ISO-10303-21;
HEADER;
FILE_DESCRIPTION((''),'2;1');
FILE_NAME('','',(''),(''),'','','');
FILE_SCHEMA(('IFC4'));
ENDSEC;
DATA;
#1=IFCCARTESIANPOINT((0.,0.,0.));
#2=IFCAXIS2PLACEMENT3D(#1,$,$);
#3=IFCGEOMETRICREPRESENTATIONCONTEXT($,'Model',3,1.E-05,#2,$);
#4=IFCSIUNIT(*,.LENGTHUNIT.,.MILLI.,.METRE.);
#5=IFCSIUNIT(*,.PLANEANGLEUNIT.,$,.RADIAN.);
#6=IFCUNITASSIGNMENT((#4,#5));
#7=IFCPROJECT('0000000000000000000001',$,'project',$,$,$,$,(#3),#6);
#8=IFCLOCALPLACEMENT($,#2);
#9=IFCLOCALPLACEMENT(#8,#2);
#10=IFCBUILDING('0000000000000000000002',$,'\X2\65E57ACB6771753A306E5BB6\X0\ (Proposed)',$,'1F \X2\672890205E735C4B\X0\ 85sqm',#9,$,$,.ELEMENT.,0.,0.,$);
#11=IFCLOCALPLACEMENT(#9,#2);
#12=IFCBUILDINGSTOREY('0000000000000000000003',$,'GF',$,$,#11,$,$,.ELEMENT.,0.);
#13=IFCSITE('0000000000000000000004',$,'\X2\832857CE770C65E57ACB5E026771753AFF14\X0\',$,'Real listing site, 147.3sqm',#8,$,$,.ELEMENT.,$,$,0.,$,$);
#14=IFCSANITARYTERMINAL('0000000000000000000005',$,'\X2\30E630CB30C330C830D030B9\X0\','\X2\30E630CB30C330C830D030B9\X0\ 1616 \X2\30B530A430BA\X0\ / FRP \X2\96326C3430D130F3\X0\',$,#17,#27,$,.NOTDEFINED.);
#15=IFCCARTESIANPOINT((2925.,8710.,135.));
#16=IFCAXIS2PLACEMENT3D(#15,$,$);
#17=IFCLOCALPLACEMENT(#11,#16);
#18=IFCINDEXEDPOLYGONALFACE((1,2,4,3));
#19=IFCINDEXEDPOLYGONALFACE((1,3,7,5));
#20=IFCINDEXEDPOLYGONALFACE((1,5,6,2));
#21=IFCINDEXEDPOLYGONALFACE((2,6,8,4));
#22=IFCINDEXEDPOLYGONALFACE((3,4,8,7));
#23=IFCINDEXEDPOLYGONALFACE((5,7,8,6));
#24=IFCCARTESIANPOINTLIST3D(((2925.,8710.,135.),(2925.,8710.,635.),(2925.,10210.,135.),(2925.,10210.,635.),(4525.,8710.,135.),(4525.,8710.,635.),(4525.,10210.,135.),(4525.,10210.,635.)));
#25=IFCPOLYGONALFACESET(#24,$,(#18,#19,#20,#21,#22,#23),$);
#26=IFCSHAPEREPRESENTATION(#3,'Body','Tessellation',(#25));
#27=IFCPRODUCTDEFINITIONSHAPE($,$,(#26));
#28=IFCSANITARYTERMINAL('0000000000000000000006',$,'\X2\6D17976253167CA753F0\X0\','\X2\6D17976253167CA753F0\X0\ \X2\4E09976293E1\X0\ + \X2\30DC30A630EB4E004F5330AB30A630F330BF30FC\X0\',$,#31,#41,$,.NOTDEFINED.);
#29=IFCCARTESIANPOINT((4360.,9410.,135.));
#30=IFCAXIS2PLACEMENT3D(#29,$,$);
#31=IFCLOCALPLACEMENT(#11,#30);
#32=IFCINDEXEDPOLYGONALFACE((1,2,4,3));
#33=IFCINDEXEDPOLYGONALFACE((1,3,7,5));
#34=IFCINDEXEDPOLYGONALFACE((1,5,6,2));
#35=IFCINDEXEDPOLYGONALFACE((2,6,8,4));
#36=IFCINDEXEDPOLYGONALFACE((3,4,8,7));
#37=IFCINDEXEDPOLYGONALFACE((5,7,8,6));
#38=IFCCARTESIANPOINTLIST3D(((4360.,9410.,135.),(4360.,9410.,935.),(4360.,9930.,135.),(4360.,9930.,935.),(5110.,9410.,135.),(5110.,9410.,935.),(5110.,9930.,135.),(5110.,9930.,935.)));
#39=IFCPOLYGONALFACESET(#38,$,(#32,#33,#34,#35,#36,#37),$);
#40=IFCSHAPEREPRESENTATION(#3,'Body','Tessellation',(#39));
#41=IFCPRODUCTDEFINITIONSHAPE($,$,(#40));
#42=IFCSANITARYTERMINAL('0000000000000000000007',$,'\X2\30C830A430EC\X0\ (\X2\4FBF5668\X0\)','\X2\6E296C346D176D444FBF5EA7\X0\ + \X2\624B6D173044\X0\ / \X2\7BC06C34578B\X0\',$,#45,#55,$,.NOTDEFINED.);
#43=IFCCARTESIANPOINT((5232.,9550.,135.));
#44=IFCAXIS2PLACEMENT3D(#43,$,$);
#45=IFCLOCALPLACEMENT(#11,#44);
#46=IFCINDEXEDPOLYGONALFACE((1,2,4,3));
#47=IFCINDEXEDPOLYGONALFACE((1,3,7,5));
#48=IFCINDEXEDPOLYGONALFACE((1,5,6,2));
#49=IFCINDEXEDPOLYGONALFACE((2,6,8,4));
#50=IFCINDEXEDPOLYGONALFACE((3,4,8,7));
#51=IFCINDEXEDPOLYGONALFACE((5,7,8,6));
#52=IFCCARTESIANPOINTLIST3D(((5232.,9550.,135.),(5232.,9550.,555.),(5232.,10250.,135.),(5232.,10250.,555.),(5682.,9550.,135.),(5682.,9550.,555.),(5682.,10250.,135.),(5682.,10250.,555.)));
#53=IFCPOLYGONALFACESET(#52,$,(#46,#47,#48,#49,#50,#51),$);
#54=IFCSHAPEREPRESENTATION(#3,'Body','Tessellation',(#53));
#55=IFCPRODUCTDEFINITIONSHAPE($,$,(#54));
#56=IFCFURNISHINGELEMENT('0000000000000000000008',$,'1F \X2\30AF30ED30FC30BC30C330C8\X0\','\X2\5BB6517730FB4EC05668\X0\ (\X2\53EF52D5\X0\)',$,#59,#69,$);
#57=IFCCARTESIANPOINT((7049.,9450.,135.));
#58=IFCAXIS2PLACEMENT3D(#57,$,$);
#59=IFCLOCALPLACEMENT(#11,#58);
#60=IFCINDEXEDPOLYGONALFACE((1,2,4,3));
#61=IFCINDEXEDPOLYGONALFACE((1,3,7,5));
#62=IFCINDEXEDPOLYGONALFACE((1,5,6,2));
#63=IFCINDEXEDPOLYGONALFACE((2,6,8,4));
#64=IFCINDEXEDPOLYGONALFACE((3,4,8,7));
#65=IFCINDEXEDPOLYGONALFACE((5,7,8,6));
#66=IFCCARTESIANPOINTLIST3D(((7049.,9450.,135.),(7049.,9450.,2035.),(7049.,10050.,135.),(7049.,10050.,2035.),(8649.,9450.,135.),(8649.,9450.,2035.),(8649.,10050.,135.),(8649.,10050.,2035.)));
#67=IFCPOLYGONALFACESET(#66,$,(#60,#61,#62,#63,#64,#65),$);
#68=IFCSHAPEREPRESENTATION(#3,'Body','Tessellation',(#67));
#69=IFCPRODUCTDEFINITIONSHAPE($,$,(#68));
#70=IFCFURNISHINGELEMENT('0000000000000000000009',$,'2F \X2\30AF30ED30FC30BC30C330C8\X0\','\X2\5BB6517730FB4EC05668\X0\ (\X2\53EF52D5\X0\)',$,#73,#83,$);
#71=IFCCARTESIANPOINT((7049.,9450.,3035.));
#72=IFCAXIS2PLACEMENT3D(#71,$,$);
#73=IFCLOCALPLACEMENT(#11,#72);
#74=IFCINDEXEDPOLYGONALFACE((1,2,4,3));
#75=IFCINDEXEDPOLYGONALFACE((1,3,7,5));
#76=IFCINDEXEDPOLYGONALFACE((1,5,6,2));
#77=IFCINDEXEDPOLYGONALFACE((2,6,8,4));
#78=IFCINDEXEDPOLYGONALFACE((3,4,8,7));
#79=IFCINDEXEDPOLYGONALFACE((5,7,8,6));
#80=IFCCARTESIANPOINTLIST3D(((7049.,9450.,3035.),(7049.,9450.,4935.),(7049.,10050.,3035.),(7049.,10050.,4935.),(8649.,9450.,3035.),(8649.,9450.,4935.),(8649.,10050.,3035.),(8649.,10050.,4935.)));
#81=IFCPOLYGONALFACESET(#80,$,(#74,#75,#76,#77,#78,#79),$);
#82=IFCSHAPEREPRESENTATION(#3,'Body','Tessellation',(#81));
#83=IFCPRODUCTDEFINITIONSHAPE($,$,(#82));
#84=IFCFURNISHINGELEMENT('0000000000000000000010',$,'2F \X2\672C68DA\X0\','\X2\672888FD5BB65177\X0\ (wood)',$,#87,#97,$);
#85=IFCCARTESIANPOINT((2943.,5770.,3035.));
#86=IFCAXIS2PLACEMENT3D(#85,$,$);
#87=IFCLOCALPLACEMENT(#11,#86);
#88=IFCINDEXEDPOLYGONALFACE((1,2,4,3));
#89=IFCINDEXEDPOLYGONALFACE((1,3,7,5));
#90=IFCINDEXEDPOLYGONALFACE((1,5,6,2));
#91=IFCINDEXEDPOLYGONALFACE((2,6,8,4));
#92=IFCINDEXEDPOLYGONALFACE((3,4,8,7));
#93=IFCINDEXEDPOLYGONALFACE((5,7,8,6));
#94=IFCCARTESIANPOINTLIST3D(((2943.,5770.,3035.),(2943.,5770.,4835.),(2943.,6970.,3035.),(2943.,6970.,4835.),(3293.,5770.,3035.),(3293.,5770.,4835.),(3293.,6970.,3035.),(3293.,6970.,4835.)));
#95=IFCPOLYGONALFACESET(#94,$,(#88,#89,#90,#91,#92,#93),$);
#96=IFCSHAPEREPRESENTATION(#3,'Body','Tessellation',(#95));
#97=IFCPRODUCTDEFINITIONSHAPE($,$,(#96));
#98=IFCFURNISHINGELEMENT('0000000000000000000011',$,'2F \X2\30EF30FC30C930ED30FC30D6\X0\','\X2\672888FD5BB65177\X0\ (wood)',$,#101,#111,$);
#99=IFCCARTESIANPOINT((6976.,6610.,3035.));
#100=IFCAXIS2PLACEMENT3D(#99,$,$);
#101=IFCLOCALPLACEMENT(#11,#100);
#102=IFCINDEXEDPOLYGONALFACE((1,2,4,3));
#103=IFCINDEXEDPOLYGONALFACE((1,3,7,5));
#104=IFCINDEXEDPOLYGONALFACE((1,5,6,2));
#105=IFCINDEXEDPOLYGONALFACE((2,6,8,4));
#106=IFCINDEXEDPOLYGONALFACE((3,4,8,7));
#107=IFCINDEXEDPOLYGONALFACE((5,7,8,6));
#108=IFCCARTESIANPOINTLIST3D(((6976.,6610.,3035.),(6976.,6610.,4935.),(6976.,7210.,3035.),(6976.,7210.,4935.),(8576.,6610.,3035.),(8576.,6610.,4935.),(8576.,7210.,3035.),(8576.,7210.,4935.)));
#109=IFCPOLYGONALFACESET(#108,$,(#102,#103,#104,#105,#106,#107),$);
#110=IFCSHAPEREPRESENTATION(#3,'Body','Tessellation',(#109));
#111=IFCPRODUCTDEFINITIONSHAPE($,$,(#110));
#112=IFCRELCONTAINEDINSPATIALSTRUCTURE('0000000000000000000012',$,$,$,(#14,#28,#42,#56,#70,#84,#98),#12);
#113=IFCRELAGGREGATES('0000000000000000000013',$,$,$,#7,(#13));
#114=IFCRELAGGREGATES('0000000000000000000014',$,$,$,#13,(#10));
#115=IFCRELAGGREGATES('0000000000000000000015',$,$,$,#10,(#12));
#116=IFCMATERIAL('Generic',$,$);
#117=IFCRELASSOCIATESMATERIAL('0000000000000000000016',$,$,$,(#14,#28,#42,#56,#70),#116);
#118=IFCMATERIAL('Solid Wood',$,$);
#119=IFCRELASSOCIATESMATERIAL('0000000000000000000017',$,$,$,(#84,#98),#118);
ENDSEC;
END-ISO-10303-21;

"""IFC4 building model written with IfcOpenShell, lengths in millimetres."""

from ifc_helpers import new_model, si_unit, frame, frame_2d, origin, place, context, project, spatial, rectangle, extrude, material, element, save


model = new_model("IFC4")

# Units and contexts
model_context = context("Model", 3, precision=1e-05, world=origin())
ifc_project = project(units=[si_unit("LENGTHUNIT", "METRE", prefix="MILLI"), si_unit("PLANEANGLEUNIT", "RADIAN")], contexts=[model_context])

# Site, building, storey
site_placement = place(None, origin())
site = spatial("IfcSite", under=ifc_project, at=site_placement, Name="茨城県日立市東町４", ObjectType="Real listing site, 147.3sqm", CompositionType="ELEMENT", RefElevation=0.0)
building_placement = place(site_placement, origin())
building = spatial("IfcBuilding", under=site, at=building_placement, Name="日立東町の家 (Proposed)", ObjectType="1F 木造平屋 85sqm", CompositionType="ELEMENT", ElevationOfRefHeight=0.0, ElevationOfTerrain=0.0)
storey_placement = place(building_placement, origin())
storey = spatial("IfcBuildingStorey", under=building, at=storey_placement, Name="GF", CompositionType="ELEMENT", Elevation=0.0)

# Shared definitions
ifc_material_1 = material(Name="Solid Wood")

# Shared definitions
ifc_material_2 = material(Name="Generic")

# Sanitary terminals
sanitary_terminal_1_placement = place(storey_placement, frame((2925.0, 8710.0, 135.0)))
element("IfcSanitaryTerminal", 1, at=sanitary_terminal_1_placement, inside=storey, material=ifc_material_2, Name="ユニットバス", Description="ユニットバス 1616 サイズ / FRP 防水パン", PredefinedType="NOTDEFINED", context=model_context, shape_type="SweptSolid", body=[
    extrude(rectangle(XDim=1600.0, YDim=1500.0, at=frame_2d((800.0, 750.0))), frame((2925.0, 8710.0, 135.0)), (0.0, 0.0, 1.0), 500.0),
])
sanitary_terminal_2_placement = place(storey_placement, frame((4360.0, 9410.0, 135.0)))
element("IfcSanitaryTerminal", 2, at=sanitary_terminal_2_placement, inside=storey, material=ifc_material_2, Name="洗面化粧台", Description="洗面化粧台 三面鏡 + ボウル一体カウンター", PredefinedType="NOTDEFINED", context=model_context, shape_type="SweptSolid", body=[
    extrude(rectangle(XDim=750.0, YDim=520.0, at=frame_2d((375.0, 260.0))), frame((4360.0, 9410.0, 135.0)), (0.0, 0.0, 1.0), 800.0),
])
sanitary_terminal_3_placement = place(storey_placement, frame((5232.0, 9550.0, 135.0)))
element("IfcSanitaryTerminal", 3, at=sanitary_terminal_3_placement, inside=storey, material=ifc_material_2, Name="トイレ (便器)", Description="温水洗浄便座 + 手洗い / 節水型", PredefinedType="NOTDEFINED", context=model_context, shape_type="SweptSolid", body=[
    extrude(rectangle(XDim=450.0, YDim=700.0, at=frame_2d((225.0, 350.0))), frame((5232.0, 9550.0, 135.0)), (0.0, 0.0, 1.0), 420.0),
])

# Furnishing elements
furnishing_1_placement = place(storey_placement, frame((7049.0, 9450.0, 135.0)))
element("IfcFurnishingElement", 4, at=furnishing_1_placement, inside=storey, material=ifc_material_2, Name="1F クローゼット", Description="家具・什器 (可動)", context=model_context, shape_type="SweptSolid", body=[
    extrude(rectangle(XDim=1600.0, YDim=600.0, at=frame_2d((800.0, 300.0))), frame((7049.0, 9450.0, 135.0)), (0.0, 0.0, 1.0), 1900.0),
])
furnishing_2_placement = place(storey_placement, frame((7049.0, 9450.0, 3035.0)))
element("IfcFurnishingElement", 5, at=furnishing_2_placement, inside=storey, material=ifc_material_2, Name="2F クローゼット", Description="家具・什器 (可動)", context=model_context, shape_type="SweptSolid", body=[
    extrude(rectangle(XDim=1600.0, YDim=600.0, at=frame_2d((800.0, 300.0))), frame((7049.0, 9450.0, 3035.0)), (0.0, 0.0, 1.0), 1900.0),
])
furnishing_3_placement = place(storey_placement, frame((2943.0, 5770.0, 3035.0)))
element("IfcFurnishingElement", 6, at=furnishing_3_placement, inside=storey, material=ifc_material_1, Name="2F 本棚", Description="木製家具 (wood)", context=model_context, shape_type="SweptSolid", body=[
    extrude(rectangle(XDim=350.0, YDim=1200.0, at=frame_2d((175.0, 600.0))), frame((2943.0, 5770.0, 3035.0)), (0.0, 0.0, 1.0), 1800.0),
])
furnishing_4_placement = place(storey_placement, frame((6976.0, 6610.0, 3035.0)))
element("IfcFurnishingElement", 7, at=furnishing_4_placement, inside=storey, material=ifc_material_1, Name="2F ワードローブ", Description="木製家具 (wood)", context=model_context, shape_type="SweptSolid", body=[
    extrude(rectangle(XDim=1600.0, YDim=600.0, at=frame_2d((800.0, 300.0))), frame((6976.0, 6610.0, 3035.0)), (0.0, 0.0, 1.0), 1900.0),
])

save(model, "model.ifc")
